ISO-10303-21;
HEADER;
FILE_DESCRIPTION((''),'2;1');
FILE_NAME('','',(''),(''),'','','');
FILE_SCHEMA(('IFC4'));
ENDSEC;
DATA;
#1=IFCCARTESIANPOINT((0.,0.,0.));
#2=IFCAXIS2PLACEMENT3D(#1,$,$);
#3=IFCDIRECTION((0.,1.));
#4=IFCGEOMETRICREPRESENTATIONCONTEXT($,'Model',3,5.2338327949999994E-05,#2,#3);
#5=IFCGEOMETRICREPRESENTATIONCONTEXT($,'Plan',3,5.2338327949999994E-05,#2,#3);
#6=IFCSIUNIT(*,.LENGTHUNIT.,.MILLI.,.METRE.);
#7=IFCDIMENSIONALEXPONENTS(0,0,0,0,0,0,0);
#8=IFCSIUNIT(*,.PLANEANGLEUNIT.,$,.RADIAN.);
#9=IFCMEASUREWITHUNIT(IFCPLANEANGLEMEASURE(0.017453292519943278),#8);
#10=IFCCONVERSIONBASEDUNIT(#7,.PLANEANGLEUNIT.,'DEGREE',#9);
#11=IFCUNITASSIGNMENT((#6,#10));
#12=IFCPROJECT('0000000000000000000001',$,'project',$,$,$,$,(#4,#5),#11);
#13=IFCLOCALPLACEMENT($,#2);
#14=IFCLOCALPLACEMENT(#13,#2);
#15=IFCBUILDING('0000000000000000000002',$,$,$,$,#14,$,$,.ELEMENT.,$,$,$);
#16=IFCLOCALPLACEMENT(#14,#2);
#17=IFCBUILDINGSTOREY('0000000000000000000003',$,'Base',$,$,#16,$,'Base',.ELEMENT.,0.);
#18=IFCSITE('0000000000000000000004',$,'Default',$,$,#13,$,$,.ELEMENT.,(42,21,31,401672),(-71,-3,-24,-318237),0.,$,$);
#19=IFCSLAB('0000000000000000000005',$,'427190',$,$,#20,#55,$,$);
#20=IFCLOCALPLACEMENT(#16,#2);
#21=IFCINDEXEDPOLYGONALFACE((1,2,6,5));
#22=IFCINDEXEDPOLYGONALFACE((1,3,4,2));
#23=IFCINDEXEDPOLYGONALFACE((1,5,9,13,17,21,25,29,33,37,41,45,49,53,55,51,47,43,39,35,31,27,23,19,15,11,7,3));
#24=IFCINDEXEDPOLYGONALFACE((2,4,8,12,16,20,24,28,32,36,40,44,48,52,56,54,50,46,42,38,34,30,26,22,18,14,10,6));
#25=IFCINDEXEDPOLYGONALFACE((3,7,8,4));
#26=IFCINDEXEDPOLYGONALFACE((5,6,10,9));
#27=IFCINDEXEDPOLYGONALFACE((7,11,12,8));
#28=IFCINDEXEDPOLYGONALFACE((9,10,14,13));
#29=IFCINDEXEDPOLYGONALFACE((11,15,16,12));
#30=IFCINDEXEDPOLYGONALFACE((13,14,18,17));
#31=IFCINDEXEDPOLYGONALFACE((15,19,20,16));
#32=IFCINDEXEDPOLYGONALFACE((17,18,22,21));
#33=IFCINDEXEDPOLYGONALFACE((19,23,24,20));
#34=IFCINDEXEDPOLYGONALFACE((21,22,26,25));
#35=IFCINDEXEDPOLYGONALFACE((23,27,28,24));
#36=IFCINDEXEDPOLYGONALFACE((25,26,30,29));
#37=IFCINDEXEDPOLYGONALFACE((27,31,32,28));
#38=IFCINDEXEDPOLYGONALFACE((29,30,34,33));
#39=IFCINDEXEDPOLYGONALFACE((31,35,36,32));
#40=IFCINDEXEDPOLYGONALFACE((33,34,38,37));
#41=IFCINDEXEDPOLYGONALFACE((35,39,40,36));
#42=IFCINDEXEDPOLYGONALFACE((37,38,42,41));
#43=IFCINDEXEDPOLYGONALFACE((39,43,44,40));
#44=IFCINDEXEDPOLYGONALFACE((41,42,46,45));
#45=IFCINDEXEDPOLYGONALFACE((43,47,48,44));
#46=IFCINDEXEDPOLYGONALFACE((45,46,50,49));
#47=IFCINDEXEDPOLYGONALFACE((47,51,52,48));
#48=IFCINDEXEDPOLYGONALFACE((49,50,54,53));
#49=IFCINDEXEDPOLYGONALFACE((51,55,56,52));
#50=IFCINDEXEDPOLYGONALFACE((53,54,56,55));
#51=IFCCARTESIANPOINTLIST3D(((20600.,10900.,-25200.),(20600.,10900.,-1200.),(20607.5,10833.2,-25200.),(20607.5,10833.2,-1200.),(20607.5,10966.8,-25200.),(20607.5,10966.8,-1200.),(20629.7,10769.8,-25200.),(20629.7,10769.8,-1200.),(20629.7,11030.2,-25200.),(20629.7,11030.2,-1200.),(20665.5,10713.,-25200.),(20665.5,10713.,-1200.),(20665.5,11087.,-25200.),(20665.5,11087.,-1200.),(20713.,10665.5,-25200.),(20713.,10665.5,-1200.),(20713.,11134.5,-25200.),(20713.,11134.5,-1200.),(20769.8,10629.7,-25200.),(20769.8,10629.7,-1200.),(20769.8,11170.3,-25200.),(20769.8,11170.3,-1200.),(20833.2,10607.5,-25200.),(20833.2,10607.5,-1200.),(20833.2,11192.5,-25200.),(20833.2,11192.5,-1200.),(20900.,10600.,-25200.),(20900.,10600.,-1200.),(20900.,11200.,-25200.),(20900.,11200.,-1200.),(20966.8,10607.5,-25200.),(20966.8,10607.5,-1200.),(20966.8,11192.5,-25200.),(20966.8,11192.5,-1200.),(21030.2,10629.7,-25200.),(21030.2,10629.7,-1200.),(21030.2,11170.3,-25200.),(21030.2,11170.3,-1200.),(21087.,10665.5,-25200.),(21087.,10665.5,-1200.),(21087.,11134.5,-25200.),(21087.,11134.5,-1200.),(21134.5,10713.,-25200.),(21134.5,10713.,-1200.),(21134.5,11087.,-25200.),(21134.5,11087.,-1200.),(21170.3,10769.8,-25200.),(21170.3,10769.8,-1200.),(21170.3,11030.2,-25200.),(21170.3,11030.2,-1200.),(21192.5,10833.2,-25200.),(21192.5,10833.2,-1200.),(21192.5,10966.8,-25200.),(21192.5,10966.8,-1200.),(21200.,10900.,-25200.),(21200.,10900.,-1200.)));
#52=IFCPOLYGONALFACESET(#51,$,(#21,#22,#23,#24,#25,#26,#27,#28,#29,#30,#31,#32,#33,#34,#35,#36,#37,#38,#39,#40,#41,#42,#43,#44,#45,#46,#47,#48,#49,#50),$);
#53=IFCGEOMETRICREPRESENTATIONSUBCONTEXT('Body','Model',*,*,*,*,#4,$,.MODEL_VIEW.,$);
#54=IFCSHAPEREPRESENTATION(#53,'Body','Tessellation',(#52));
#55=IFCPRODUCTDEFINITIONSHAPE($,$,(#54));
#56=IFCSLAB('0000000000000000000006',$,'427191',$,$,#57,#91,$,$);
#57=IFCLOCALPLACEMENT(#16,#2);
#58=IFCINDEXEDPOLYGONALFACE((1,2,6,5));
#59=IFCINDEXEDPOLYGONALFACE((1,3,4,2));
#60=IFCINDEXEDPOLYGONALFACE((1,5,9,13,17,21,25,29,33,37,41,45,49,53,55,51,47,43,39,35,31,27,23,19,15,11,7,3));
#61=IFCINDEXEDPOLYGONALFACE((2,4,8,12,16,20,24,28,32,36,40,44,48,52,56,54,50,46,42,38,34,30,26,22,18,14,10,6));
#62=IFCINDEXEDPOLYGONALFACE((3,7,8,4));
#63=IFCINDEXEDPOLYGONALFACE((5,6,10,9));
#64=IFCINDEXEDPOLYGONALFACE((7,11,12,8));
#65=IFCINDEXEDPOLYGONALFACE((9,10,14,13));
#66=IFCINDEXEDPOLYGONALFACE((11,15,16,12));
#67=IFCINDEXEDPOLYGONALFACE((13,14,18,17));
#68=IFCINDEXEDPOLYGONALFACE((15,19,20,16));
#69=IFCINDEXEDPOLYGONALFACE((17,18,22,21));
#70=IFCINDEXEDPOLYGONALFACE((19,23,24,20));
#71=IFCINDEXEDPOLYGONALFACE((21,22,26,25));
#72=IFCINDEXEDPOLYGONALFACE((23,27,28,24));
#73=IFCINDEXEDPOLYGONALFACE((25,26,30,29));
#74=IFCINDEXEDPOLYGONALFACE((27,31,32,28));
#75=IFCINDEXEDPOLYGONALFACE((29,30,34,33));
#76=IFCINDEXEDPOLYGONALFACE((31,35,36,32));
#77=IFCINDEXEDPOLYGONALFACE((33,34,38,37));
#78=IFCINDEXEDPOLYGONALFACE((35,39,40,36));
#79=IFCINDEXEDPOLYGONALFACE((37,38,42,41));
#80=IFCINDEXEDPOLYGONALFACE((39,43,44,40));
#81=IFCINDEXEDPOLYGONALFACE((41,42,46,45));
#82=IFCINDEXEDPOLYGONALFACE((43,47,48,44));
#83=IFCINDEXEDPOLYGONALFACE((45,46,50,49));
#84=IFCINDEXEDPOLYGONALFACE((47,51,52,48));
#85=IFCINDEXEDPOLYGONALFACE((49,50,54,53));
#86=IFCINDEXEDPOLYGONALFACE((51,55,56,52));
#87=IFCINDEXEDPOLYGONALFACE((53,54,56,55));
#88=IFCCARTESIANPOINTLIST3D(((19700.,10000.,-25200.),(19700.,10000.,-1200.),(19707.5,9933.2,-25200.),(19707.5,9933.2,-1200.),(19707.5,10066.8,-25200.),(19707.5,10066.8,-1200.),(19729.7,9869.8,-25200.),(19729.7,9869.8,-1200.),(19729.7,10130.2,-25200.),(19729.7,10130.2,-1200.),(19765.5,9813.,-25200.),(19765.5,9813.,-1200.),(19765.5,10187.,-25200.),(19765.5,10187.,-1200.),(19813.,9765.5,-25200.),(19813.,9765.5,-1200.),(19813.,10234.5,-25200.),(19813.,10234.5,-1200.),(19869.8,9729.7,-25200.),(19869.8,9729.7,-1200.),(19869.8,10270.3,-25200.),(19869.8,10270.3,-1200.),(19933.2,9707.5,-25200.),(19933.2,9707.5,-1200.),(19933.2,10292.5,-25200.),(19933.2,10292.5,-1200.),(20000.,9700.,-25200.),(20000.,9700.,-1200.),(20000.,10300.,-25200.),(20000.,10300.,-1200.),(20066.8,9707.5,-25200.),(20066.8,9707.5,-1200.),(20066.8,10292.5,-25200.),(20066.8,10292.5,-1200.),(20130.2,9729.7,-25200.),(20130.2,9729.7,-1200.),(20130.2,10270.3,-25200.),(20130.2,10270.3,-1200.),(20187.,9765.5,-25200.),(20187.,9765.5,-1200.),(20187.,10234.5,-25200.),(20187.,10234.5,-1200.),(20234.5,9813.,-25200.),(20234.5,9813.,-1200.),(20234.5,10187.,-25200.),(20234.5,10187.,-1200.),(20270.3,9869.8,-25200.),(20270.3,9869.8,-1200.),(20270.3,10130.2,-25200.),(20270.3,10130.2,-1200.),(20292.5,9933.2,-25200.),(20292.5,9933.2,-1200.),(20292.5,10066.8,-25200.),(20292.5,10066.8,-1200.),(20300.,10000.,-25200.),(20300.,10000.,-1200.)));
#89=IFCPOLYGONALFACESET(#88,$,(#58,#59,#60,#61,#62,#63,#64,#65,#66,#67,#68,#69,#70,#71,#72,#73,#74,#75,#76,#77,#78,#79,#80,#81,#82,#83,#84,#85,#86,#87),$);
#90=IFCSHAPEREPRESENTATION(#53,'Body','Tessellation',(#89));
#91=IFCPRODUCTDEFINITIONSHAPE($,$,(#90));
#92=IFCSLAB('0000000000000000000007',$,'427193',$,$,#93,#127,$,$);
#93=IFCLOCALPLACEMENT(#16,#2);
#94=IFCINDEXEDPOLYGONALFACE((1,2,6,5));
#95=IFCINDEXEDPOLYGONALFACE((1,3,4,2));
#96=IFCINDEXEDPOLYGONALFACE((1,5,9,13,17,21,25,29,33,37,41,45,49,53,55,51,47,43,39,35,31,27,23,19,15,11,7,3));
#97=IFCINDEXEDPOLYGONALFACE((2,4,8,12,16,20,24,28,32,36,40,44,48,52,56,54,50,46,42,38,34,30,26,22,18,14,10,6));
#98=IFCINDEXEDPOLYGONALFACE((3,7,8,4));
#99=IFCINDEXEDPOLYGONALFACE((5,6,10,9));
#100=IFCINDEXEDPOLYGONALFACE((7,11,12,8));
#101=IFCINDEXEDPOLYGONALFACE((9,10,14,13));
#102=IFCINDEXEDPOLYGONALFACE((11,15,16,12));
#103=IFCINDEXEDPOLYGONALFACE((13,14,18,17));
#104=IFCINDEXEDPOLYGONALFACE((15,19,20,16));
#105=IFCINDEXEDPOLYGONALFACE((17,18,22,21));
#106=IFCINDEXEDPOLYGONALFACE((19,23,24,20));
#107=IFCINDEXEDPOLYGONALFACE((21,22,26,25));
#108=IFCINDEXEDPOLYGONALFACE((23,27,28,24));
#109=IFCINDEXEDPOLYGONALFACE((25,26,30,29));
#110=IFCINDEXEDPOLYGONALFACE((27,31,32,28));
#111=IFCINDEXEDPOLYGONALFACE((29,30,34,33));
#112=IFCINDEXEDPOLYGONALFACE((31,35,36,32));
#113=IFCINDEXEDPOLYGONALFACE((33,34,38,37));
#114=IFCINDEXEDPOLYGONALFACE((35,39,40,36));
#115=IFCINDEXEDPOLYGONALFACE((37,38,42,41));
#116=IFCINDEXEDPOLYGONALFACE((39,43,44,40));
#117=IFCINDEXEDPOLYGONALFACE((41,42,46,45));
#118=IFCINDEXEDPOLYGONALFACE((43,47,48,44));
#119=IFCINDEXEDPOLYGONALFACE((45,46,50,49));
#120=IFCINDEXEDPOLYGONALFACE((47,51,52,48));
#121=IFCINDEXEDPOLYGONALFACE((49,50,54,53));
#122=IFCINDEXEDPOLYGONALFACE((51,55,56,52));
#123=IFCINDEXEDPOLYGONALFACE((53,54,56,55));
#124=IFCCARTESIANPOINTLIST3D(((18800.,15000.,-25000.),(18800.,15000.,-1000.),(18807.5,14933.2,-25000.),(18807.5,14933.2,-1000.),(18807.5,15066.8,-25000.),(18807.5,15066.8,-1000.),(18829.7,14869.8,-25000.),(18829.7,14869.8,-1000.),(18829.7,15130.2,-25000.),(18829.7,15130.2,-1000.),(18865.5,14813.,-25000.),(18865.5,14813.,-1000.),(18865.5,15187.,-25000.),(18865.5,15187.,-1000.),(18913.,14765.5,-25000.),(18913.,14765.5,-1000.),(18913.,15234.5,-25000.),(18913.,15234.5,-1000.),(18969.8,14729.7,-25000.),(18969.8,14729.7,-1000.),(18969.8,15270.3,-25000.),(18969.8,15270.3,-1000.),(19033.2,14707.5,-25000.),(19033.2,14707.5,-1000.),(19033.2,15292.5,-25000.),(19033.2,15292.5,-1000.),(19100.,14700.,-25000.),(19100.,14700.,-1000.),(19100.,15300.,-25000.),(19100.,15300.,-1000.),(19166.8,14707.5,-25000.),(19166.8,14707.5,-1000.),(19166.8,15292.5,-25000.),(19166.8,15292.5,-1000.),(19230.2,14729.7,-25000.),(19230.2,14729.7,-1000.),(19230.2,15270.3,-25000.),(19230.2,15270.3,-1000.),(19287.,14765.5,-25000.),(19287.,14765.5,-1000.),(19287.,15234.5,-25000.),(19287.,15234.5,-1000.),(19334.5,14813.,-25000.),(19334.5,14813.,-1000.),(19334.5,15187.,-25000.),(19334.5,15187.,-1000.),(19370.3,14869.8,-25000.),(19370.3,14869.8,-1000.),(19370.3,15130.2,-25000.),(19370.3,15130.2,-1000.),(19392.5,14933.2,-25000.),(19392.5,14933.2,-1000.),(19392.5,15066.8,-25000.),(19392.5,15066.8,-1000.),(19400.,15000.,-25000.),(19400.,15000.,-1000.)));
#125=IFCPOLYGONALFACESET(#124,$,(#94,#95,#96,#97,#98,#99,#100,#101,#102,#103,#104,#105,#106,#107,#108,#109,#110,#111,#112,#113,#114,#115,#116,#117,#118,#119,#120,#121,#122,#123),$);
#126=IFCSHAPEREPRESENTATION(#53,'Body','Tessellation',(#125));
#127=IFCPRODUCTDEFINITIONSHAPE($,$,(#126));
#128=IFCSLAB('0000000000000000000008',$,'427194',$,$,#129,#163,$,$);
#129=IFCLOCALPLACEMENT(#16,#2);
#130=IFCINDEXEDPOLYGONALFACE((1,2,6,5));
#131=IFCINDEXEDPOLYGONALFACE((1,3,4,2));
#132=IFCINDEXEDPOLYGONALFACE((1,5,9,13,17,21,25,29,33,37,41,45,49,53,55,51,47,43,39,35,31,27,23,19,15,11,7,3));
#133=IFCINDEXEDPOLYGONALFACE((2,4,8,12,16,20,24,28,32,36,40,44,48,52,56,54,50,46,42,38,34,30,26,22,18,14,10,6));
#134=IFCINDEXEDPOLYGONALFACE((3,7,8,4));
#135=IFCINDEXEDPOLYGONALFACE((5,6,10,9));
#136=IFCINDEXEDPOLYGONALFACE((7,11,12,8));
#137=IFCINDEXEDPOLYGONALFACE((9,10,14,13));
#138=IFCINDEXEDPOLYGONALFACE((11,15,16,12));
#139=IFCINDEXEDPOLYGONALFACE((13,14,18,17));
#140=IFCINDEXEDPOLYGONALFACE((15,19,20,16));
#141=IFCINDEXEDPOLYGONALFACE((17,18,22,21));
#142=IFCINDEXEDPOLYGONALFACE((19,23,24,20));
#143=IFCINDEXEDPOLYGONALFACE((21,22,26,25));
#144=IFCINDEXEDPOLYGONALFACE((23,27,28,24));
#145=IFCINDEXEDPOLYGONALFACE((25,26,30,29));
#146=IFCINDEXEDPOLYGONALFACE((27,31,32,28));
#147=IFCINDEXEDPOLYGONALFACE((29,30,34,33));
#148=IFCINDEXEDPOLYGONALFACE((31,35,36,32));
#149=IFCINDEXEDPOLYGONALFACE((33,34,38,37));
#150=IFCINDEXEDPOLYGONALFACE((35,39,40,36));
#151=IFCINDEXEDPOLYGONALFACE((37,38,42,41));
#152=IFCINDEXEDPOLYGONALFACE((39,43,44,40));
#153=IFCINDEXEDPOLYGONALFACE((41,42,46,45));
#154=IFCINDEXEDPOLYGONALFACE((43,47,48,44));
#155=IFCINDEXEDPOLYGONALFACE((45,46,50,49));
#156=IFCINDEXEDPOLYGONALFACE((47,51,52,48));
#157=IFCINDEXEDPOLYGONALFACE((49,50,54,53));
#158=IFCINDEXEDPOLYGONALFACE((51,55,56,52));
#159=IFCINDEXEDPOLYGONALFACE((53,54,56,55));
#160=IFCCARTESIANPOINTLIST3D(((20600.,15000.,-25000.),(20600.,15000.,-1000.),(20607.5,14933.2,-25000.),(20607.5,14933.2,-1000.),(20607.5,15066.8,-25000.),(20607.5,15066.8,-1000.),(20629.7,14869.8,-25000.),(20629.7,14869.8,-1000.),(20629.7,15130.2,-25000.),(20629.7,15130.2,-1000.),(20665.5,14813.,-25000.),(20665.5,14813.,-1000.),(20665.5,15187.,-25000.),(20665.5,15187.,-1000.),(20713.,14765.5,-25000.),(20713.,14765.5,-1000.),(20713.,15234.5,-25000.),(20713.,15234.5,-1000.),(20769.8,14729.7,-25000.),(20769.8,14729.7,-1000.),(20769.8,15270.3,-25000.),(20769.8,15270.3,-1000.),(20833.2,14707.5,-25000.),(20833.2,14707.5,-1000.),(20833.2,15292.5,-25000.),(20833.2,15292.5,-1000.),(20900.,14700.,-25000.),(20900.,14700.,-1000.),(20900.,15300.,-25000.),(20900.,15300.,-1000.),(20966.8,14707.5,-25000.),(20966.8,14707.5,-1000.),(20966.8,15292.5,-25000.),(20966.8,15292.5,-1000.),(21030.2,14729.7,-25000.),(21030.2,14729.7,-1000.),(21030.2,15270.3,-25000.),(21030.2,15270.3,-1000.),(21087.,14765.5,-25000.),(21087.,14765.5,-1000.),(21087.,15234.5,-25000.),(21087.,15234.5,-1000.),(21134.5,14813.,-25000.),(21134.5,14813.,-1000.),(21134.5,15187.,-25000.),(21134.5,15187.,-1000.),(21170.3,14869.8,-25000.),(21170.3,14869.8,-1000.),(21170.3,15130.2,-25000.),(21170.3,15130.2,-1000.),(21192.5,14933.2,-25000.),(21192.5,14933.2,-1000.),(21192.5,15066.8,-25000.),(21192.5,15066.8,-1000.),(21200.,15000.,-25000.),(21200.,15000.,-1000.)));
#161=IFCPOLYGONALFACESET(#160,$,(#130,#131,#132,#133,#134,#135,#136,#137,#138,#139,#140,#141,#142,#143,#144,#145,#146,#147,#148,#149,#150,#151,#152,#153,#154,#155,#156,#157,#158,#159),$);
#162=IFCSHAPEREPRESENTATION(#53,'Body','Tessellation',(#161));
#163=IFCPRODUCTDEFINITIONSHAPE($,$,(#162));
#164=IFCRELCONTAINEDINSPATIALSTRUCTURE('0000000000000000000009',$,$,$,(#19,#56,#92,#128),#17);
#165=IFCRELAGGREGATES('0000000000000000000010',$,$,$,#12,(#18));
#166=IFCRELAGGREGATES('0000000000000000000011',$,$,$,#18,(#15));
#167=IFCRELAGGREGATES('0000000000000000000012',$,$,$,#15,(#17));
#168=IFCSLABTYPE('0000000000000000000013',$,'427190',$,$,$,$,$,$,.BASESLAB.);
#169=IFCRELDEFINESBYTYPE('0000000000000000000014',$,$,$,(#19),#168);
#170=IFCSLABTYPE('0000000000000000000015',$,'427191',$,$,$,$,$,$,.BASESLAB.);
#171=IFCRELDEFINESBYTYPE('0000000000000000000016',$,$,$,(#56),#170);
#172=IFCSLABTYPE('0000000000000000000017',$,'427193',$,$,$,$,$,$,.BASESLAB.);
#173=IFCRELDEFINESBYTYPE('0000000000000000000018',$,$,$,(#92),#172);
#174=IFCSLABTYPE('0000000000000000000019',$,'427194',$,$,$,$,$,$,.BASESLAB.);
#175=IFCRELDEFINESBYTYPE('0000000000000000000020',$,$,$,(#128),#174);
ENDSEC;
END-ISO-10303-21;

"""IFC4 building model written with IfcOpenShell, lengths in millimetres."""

from ifc_helpers import new_model, entity, si_unit, converted_unit, direction, frame, origin, place, context, subcontext, project, spatial, arc, indexed_curve, outline, extrude, type_object, element, save


model = new_model("IFC4")

# Units and contexts
model_context = context("Model", 3, precision=5.2338327949999994e-05, world=origin(), true_north=direction((0.0, 1.0)))
plan_context = context("Plan", 3, precision=5.2338327949999994e-05, world=origin(), true_north=direction((0.0, 1.0)))
body_context = subcontext(model_context, "Body", "Model", "MODEL_VIEW")
ifc_project = project(units=[si_unit("LENGTHUNIT", "METRE", prefix="MILLI"), converted_unit("PLANEANGLEUNIT", "DEGREE", entity("IfcPlaneAngleMeasure", 0.017453292519943278), si_unit("PLANEANGLEUNIT", "RADIAN"), dimensions=[0, 0, 0, 0, 0, 0, 0])], contexts=[model_context, plan_context])

# Site, building, storey
site_placement = place(None, origin())
site = spatial("IfcSite", under=ifc_project, at=site_placement, Name="Default", CompositionType="ELEMENT", RefLatitude=(42, 21, 31, 401672), RefLongitude=(-71, -3, -24, -318237), RefElevation=0.0)
building_placement = place(site_placement, origin())
building = spatial("IfcBuilding", under=site, at=building_placement, CompositionType="ELEMENT")
storey_placement = place(building_placement, origin())
storey = spatial("IfcBuildingStorey", under=building, at=storey_placement, Name="Base", LongName="Base", CompositionType="ELEMENT", Elevation=0.0)

# Slabs
slab_type_1 = type_object("IfcSlabType", Name="427190", PredefinedType="BASESLAB")
slab_1_placement = place(storey_placement, origin())
element("IfcSlab", 1, at=slab_1_placement, inside=storey, type_object=slab_type_1, Name="427190", context=body_context, shape_type="SweptSolid", body=[
    extrude(outline(indexed_curve([(300.0, 0.0), (0.0, 300.0), (-300.0, 0.0), (0.0, -300.0)], segments=[arc(1, 2, 3), arc(3, 4, 1)], self_intersect=False)), frame((20900.0, 10900.0, -25200.0)), (0.0, 0.0, 1.0), 24000.0),
])
slab_type_2 = type_object("IfcSlabType", Name="427191", PredefinedType="BASESLAB")
slab_2_placement = place(storey_placement, origin())
element("IfcSlab", 2, at=slab_2_placement, inside=storey, type_object=slab_type_2, Name="427191", context=body_context, shape_type="SweptSolid", body=[
    extrude(outline(indexed_curve([(300.0, 0.0), (0.0, 300.0), (-300.0, 0.0), (0.0, -300.0)], segments=[arc(1, 2, 3), arc(3, 4, 1)], self_intersect=False)), frame((20000.0, 10000.0, -25200.0)), (0.0, 0.0, 1.0), 24000.0),
])
slab_type_3 = type_object("IfcSlabType", Name="427193", PredefinedType="BASESLAB")
slab_3_placement = place(storey_placement, origin())
element("IfcSlab", 3, at=slab_3_placement, inside=storey, type_object=slab_type_3, Name="427193", context=body_context, shape_type="SweptSolid", body=[
    extrude(outline(indexed_curve([(300.0, 0.0), (0.0, 300.0), (-300.0, 0.0), (0.0, -300.0)], segments=[arc(1, 2, 3), arc(3, 4, 1)], self_intersect=False)), frame((19100.0, 15000.0, -25000.0)), (0.0, 0.0, 1.0), 24000.0),
])
slab_type_4 = type_object("IfcSlabType", Name="427194", PredefinedType="BASESLAB")
slab_4_placement = place(storey_placement, origin())
element("IfcSlab", 4, at=slab_4_placement, inside=storey, type_object=slab_type_4, Name="427194", context=body_context, shape_type="SweptSolid", body=[
    extrude(outline(indexed_curve([(300.0, 0.0), (0.0, 300.0), (-300.0, 0.0), (0.0, -300.0)], segments=[arc(1, 2, 3), arc(3, 4, 1)], self_intersect=False)), frame((20900.0, 15000.0, -25000.0)), (0.0, 0.0, 1.0), 24000.0),
])

save(model, "model.ifc")
